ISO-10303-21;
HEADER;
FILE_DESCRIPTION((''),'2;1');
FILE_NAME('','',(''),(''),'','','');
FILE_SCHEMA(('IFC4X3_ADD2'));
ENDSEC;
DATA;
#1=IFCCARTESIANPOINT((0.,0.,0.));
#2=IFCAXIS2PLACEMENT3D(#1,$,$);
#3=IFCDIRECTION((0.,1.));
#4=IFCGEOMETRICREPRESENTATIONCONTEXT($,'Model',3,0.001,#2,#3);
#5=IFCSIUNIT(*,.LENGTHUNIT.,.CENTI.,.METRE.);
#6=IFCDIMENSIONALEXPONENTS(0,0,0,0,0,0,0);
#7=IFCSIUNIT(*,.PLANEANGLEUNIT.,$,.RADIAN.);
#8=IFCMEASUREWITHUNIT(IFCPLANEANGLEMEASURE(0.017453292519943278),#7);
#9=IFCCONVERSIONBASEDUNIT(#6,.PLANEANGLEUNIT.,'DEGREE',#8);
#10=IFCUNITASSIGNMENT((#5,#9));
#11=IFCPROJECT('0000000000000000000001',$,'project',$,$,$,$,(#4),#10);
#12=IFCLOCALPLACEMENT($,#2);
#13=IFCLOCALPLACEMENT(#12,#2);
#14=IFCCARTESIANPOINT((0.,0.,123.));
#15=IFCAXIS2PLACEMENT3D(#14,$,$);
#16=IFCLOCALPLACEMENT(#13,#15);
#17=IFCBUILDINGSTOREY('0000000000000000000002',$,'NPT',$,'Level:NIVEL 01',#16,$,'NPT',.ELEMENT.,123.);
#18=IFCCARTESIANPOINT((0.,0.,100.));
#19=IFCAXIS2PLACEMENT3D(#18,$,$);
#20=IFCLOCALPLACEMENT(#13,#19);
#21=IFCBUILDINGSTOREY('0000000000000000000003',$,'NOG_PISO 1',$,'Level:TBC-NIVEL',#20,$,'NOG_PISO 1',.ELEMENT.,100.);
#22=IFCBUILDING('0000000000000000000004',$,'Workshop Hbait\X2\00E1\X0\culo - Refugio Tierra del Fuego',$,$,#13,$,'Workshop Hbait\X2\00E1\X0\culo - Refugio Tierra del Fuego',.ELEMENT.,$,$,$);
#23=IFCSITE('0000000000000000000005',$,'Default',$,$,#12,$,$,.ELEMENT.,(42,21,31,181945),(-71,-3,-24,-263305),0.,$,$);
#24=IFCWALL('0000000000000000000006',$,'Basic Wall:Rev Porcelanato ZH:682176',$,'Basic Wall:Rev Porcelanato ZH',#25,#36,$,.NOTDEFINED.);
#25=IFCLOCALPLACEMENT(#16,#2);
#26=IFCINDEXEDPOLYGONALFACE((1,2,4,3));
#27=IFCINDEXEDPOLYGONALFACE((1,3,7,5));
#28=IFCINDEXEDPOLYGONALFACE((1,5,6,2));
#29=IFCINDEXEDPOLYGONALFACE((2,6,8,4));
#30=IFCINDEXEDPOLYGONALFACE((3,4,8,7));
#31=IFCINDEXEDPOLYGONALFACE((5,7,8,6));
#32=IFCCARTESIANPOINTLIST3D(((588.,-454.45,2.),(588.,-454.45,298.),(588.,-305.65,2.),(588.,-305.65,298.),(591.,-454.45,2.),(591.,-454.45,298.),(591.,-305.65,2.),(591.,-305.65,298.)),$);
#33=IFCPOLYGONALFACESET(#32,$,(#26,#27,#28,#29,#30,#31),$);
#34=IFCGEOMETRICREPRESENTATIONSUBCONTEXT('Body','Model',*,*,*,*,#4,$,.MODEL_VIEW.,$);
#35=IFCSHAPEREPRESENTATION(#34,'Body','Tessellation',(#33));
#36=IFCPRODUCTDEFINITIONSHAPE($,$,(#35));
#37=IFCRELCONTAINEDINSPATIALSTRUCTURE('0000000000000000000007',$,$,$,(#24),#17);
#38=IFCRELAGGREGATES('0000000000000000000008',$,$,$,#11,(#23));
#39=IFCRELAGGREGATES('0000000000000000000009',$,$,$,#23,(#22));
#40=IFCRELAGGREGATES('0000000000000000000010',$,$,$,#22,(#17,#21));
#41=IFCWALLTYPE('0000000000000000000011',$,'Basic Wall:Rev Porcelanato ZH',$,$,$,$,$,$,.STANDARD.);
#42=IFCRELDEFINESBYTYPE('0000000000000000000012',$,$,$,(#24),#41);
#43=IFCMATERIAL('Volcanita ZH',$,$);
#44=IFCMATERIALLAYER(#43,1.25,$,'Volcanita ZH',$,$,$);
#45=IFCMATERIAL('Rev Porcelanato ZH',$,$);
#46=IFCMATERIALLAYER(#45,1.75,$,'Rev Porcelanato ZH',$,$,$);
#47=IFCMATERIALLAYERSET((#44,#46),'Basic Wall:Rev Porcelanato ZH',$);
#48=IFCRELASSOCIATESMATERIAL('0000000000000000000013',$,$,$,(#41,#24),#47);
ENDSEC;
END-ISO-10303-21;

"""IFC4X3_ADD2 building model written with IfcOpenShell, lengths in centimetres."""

from ifc_helpers import new_model, entity, si_unit, converted_unit, direction, frame, frame_2d, origin, place, context, subcontext, project, spatial, rectangle, extrude, material, layer, layer_set, type_object, element, save


model = new_model("IFC4X3_ADD2")

# Units and contexts
model_context = context("Model", 3, precision=0.001, world=origin(), true_north=direction((0.0, 1.0)))
body_context = subcontext(model_context, "Body", "Model", "MODEL_VIEW")
ifc_project = project(units=[si_unit("LENGTHUNIT", "METRE", prefix="CENTI"), converted_unit("PLANEANGLEUNIT", "DEGREE", entity("IfcPlaneAngleMeasure", 0.017453292519943278), si_unit("PLANEANGLEUNIT", "RADIAN"), dimensions=[0, 0, 0, 0, 0, 0, 0])], contexts=[model_context])

# Site, building, storey
site_placement = place(None, origin())
site = spatial("IfcSite", under=ifc_project, at=site_placement, Name="Default", CompositionType="ELEMENT", RefLatitude=(42, 21, 31, 181945), RefLongitude=(-71, -3, -24, -263305), RefElevation=0.0)
building_placement = place(site_placement, origin())
building = spatial("IfcBuilding", under=site, at=building_placement, Name="Workshop Hbaitáculo - Refugio Tierra del Fuego", LongName="Workshop Hbaitáculo - Refugio Tierra del Fuego", CompositionType="ELEMENT")
storey_1_placement = place(building_placement, frame((0.0, 0.0, 123.0)))
storey_1 = spatial("IfcBuildingStorey", under=building, at=storey_1_placement, Name="NPT", ObjectType="Level:NIVEL 01", LongName="NPT", CompositionType="ELEMENT", Elevation=123.0)

# Shared definitions
storey_2_placement = place(building_placement, frame((0.0, 0.0, 100.0)))
storey_2 = spatial("IfcBuildingStorey", under=building, at=storey_2_placement, Name="NOG_PISO 1", ObjectType="Level:TBC-NIVEL", LongName="NOG_PISO 1", CompositionType="ELEMENT", Elevation=100.0)

# Wall
ifc_material_1 = material(Name="Volcanita ZH")
ifc_layer_1 = layer(ifc_material_1, 1.25, Name="Volcanita ZH")
ifc_material_2 = material(Name="Rev Porcelanato ZH")
ifc_layer_2 = layer(ifc_material_2, 1.75, Name="Rev Porcelanato ZH")
ifc_layer_set_1 = layer_set([ifc_layer_1, ifc_layer_2], Name="Basic Wall:Rev Porcelanato ZH")
wall_type_1 = type_object("IfcWallType", Name="Basic Wall:Rev Porcelanato ZH", PredefinedType="STANDARD", material=ifc_layer_set_1)
wall_1_placement = place(storey_1_placement, frame((589.5, -454.45, 2.0), z_axis=(0.0, 0.0, 1.0), x_axis=(0.0, 1.0, 0.0)))
element("IfcWall", 1, at=wall_1_placement, inside=storey_1, type_object=wall_type_1, material=ifc_layer_set_1, Name="Basic Wall:Rev Porcelanato ZH:682176", ObjectType="Basic Wall:Rev Porcelanato ZH", PredefinedType="NOTDEFINED", context=body_context, shape_type="SweptSolid", body=[
    extrude(rectangle(XDim=148.8, YDim=3.0, at=frame_2d((74.4, 0.0), x_axis=(-1.0, 0.0))), origin(), (0.0, 0.0, 1.0), 296.0),
])

save(model, "model.ifc")
